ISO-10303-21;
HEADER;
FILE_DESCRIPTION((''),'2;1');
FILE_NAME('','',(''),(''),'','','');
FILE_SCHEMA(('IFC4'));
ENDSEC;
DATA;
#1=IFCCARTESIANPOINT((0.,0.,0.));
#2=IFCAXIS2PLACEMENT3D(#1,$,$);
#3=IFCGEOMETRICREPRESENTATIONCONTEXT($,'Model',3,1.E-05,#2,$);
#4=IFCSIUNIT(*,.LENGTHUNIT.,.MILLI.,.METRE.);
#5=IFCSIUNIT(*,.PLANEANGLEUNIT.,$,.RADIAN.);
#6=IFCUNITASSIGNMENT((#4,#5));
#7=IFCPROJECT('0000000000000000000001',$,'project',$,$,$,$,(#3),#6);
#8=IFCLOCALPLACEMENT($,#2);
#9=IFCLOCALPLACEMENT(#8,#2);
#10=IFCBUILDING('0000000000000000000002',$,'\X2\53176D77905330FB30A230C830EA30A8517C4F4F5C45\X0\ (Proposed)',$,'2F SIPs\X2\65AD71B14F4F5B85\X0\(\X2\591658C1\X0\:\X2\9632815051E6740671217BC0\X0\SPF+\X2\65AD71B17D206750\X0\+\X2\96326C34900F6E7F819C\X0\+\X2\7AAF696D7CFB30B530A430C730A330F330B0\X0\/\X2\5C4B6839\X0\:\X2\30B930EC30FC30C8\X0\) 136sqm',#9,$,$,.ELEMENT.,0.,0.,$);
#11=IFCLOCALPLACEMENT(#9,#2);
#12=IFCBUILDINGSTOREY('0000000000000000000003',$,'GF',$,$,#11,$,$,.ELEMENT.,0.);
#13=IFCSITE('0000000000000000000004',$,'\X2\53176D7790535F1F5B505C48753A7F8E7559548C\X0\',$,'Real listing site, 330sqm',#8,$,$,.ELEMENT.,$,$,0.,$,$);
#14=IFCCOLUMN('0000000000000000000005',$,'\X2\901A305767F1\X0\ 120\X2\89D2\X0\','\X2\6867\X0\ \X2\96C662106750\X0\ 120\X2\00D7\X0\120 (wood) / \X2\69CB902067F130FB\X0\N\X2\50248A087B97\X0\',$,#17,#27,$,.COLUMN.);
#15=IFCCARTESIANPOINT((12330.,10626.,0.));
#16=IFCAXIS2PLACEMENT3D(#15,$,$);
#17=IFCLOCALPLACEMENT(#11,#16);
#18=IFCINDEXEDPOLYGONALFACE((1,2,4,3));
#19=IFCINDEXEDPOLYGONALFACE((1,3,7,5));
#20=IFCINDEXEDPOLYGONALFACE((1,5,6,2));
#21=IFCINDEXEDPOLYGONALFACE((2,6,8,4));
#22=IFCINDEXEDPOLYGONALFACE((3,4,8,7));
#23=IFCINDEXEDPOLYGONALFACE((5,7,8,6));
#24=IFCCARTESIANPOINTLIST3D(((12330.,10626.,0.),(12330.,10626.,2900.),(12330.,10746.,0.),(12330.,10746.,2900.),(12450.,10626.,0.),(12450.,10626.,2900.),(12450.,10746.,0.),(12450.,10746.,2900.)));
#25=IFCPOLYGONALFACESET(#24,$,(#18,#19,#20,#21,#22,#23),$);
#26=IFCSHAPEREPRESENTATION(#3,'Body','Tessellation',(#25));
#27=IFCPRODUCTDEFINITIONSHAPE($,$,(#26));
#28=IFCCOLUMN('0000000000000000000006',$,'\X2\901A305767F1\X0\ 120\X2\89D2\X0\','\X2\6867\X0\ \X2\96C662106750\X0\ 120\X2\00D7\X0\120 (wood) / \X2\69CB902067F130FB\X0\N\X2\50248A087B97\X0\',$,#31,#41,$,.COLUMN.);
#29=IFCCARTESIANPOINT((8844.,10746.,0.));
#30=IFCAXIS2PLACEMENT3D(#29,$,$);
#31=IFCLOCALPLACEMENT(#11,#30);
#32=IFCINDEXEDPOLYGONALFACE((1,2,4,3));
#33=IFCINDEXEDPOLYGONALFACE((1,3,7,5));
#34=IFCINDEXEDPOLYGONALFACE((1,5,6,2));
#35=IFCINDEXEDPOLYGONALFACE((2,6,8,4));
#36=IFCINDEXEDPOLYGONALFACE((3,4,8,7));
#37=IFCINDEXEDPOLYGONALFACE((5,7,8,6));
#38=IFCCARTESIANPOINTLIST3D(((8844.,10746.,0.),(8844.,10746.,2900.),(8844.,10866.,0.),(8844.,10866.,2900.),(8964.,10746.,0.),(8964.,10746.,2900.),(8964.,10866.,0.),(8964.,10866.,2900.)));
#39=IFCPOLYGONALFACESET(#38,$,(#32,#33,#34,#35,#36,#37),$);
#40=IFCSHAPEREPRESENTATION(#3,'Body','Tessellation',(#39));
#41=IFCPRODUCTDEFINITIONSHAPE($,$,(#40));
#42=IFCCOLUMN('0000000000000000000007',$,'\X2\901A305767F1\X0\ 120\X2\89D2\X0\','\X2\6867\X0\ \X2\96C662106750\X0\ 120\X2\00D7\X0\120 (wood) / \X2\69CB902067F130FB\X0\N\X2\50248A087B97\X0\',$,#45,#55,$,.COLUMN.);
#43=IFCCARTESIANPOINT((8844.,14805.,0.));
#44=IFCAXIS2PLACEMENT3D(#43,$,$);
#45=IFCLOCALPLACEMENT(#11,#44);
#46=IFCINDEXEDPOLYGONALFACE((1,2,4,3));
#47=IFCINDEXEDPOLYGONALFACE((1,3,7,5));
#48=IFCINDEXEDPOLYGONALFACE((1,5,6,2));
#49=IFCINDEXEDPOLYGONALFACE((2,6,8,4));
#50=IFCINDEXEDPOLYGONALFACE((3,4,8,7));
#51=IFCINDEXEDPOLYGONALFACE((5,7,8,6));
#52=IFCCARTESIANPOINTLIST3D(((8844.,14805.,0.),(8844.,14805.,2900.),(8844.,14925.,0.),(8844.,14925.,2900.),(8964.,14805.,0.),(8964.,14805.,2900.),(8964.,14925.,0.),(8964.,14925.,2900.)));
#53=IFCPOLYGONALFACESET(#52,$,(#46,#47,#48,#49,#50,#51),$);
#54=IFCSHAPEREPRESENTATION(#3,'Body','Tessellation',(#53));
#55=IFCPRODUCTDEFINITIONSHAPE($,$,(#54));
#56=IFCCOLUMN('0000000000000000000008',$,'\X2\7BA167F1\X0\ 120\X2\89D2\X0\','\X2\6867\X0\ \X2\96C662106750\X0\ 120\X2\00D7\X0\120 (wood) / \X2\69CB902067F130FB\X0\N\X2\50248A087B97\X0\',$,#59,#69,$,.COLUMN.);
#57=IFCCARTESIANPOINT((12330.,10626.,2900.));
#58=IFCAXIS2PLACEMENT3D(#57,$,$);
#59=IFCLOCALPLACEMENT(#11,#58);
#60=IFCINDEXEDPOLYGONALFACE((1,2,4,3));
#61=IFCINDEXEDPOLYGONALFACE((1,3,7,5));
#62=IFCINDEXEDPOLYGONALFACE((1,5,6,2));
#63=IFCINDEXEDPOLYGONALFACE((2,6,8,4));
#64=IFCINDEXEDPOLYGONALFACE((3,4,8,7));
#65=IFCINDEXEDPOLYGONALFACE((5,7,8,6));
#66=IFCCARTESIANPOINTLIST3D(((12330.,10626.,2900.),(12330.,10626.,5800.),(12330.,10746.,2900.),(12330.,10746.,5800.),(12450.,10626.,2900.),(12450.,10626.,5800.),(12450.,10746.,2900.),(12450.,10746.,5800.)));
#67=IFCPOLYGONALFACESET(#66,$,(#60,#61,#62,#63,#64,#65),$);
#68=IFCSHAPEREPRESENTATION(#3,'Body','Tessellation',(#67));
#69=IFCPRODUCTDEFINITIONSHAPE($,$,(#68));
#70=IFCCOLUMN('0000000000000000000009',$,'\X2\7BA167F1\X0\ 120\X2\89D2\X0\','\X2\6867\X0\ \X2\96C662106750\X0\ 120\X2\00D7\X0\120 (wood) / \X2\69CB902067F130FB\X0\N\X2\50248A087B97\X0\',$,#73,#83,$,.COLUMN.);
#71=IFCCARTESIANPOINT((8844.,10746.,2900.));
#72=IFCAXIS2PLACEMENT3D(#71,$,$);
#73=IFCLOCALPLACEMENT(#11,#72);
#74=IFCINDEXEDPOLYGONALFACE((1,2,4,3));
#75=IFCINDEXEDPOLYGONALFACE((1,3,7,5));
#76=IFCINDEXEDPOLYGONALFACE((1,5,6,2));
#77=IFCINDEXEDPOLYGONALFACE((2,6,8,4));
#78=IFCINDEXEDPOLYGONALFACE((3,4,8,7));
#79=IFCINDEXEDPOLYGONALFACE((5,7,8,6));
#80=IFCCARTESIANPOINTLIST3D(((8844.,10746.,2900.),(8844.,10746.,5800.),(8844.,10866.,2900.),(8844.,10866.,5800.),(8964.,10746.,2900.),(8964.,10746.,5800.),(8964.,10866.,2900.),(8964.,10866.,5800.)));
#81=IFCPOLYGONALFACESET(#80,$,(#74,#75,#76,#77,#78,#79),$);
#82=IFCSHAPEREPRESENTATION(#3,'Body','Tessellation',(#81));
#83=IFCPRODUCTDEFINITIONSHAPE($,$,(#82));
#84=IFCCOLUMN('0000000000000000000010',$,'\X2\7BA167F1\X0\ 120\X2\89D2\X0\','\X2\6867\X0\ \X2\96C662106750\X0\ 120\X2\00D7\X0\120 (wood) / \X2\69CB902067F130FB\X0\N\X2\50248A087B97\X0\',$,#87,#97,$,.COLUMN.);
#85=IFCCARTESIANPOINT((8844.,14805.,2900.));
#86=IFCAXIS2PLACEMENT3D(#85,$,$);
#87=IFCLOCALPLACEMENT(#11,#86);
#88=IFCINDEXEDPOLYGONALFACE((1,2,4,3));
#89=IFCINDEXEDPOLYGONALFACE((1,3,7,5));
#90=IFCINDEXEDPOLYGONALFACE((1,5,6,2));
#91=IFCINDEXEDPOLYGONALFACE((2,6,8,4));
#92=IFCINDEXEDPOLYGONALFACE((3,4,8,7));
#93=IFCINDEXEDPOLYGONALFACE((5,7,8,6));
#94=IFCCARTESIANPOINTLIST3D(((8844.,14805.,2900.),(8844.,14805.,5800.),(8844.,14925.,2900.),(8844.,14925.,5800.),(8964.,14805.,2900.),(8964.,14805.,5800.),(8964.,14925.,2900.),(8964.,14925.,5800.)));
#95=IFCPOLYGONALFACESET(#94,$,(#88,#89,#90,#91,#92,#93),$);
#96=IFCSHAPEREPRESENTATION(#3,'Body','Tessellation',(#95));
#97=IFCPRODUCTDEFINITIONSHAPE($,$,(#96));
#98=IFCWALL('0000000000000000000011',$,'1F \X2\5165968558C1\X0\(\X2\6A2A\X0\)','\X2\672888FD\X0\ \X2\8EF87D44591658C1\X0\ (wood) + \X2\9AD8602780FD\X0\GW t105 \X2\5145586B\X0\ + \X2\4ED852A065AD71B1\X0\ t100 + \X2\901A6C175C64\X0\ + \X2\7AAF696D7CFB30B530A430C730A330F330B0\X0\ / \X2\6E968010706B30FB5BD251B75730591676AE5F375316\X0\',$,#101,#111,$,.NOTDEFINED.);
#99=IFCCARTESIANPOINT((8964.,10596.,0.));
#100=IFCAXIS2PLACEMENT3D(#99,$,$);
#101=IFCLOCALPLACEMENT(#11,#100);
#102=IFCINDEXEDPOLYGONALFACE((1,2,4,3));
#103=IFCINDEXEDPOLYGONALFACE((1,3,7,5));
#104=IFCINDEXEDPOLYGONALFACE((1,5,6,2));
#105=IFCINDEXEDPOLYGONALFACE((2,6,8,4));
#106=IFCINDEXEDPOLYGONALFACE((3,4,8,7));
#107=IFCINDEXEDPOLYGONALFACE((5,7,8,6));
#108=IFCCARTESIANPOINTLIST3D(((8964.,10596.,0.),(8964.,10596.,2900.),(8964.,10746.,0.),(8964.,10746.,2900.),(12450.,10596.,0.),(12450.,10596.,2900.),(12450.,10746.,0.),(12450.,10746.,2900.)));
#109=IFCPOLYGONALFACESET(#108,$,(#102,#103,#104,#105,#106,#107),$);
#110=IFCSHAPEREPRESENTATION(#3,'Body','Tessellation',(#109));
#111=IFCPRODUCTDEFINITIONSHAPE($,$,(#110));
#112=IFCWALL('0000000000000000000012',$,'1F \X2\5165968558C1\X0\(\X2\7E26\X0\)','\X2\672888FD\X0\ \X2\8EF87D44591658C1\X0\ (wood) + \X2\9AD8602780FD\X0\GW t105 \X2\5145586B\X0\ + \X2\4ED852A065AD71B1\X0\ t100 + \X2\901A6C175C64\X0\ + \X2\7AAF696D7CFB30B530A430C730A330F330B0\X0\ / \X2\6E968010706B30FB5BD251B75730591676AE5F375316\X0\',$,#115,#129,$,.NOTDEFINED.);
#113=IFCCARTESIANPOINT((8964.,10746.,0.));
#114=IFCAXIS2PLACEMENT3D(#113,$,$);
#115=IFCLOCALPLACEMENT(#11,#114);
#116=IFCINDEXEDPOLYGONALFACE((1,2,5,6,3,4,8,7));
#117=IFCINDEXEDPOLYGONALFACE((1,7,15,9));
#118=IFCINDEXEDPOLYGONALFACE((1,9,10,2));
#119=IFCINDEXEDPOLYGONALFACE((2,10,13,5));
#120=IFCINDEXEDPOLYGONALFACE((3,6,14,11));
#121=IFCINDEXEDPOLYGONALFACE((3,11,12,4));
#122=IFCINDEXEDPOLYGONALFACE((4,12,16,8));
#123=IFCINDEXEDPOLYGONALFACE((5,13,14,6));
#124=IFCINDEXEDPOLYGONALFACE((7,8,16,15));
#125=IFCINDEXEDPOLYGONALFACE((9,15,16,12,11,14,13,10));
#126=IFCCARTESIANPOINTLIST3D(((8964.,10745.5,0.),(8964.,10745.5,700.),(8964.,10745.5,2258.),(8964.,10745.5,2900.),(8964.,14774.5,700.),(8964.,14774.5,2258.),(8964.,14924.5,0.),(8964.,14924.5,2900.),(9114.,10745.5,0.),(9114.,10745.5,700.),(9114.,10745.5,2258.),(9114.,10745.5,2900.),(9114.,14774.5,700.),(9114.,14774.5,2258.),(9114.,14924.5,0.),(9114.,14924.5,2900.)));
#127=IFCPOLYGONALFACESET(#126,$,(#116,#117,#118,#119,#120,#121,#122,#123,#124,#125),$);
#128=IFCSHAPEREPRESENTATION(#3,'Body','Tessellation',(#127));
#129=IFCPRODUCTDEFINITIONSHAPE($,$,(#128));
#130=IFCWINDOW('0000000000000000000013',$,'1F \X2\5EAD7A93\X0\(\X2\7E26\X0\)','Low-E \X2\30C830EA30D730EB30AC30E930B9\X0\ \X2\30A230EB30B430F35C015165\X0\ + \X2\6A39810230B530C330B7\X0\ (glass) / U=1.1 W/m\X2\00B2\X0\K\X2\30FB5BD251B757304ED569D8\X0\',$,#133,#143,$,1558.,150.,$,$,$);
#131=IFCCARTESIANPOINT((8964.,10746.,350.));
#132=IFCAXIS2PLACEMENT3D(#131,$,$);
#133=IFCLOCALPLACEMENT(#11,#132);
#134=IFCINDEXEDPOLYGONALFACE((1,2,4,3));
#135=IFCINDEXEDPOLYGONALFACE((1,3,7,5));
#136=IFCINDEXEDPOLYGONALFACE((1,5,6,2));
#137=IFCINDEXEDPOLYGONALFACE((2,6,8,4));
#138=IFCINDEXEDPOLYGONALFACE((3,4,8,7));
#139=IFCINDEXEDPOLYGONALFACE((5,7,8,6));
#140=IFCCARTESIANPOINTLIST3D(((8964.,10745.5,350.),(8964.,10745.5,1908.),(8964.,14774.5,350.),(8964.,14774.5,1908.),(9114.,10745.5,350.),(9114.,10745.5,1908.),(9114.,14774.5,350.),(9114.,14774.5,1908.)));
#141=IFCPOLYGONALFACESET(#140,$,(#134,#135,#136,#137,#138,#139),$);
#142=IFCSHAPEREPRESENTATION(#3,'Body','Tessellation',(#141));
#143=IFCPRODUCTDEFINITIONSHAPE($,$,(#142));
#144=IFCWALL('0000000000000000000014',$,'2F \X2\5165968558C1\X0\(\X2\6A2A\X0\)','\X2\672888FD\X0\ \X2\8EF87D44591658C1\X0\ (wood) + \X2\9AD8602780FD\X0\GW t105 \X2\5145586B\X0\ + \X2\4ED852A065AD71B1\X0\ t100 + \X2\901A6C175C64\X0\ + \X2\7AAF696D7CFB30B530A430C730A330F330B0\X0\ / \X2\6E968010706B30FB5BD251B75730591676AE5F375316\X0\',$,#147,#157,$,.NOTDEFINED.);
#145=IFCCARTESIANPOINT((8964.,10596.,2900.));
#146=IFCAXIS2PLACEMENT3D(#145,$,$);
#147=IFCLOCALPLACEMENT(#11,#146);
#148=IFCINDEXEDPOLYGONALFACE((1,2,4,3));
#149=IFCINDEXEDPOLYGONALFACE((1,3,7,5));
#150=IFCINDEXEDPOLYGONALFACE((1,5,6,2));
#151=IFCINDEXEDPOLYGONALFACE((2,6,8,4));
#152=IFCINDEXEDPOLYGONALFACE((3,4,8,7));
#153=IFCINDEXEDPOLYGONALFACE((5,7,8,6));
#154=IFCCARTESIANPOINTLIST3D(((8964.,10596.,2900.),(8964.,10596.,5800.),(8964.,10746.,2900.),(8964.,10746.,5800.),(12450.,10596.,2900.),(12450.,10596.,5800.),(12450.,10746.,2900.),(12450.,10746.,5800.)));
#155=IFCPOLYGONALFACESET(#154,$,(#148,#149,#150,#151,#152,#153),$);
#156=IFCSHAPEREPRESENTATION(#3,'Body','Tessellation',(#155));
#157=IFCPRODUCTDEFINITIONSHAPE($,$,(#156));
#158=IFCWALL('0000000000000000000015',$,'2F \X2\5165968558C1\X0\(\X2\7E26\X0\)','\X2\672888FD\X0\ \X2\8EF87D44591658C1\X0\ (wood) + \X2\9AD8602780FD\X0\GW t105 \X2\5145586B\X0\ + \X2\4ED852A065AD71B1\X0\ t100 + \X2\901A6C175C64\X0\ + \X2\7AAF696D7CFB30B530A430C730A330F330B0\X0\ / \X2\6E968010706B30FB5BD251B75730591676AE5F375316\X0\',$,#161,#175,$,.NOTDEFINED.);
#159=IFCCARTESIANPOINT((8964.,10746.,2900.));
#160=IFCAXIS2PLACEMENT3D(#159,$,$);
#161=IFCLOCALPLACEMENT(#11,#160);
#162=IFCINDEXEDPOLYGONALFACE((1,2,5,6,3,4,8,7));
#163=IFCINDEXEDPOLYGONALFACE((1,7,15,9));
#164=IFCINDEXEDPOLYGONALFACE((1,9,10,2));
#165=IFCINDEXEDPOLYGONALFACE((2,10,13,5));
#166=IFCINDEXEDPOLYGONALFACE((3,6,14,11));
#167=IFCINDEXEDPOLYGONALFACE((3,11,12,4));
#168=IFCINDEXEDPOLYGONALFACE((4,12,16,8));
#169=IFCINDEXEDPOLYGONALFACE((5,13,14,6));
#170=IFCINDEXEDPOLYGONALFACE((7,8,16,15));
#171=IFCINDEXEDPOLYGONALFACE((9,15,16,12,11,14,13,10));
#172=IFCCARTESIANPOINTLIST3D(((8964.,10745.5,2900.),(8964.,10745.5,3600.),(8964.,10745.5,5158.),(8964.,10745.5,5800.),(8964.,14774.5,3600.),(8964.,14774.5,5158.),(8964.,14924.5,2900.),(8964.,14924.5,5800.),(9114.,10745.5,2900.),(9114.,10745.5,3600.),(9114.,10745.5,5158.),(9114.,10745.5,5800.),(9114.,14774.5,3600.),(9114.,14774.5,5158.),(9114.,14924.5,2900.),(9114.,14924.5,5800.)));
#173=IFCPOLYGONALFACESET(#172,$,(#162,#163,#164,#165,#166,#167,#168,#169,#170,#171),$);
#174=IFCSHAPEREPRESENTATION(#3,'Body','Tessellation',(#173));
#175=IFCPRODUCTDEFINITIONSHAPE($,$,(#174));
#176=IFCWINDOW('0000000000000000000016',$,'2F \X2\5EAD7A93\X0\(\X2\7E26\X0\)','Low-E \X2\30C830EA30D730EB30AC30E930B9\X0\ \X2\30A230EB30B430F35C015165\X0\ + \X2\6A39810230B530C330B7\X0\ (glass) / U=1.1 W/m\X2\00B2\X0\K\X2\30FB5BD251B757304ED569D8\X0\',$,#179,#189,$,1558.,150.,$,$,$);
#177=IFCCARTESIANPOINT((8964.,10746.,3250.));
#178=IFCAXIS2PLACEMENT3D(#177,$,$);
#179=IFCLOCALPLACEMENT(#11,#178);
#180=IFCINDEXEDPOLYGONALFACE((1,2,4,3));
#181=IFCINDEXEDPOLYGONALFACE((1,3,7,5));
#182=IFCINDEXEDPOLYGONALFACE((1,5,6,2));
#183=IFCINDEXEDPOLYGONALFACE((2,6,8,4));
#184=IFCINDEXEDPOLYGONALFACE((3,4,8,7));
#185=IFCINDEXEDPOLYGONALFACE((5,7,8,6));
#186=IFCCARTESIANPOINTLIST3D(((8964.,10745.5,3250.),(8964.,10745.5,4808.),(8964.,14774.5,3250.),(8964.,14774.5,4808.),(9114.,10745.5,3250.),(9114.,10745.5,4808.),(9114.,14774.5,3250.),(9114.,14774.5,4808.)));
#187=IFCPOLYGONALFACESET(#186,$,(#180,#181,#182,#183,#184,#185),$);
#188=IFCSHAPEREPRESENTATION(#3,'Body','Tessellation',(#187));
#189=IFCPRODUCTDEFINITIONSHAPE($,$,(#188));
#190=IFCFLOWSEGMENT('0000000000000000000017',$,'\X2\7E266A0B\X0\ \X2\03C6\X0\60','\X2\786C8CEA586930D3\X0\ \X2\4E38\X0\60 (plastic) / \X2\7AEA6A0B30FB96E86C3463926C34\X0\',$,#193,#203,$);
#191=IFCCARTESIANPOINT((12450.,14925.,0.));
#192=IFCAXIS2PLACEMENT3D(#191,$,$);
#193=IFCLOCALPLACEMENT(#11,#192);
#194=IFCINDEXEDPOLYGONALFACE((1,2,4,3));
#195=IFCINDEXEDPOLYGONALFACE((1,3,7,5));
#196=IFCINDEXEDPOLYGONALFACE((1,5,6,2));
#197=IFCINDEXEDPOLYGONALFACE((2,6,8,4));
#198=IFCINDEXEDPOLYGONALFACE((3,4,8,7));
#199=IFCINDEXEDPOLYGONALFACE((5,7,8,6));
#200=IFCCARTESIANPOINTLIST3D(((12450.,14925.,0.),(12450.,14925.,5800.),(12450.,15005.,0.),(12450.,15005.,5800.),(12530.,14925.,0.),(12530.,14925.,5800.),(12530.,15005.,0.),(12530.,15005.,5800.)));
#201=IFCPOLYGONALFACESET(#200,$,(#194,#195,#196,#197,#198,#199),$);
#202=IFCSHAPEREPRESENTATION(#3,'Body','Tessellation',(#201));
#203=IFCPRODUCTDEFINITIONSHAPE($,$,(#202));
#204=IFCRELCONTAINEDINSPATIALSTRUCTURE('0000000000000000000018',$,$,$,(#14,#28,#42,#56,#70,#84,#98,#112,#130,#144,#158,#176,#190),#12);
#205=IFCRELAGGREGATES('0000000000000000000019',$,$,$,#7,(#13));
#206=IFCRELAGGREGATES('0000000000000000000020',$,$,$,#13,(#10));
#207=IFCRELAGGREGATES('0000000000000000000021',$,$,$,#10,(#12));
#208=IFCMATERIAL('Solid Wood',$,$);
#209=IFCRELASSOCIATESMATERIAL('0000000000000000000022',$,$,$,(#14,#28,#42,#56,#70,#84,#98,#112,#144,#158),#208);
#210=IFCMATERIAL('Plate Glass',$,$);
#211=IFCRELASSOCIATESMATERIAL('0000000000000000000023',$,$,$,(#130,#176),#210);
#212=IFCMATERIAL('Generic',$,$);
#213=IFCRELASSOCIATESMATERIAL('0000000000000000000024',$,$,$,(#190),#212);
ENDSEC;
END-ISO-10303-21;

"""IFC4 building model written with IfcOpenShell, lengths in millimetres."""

from ifc_helpers import new_model, si_unit, frame, frame_2d, origin, place, context, project, spatial, rectangle, extrude, material, element, fill, save


model = new_model("IFC4")

# Units and contexts
model_context = context("Model", 3, precision=1e-05, world=origin())
ifc_project = project(units=[si_unit("LENGTHUNIT", "METRE", prefix="MILLI"), si_unit("PLANEANGLEUNIT", "RADIAN")], contexts=[model_context])

# Site, building, storey
site_placement = place(None, origin())
site = spatial("IfcSite", under=ifc_project, at=site_placement, Name="北海道弟子屈町美留和", ObjectType="Real listing site, 330sqm", CompositionType="ELEMENT", RefElevation=0.0)
building_placement = place(site_placement, origin())
building = spatial("IfcBuilding", under=site, at=building_placement, Name="北海道・アトリエ兼住居 (Proposed)", ObjectType="2F SIPs断熱住宅(外壁:防腐処理無節SPF+断熱素材+防水透湿膜+窯業系サイディング/屋根:スレート) 136sqm", CompositionType="ELEMENT", ElevationOfRefHeight=0.0, ElevationOfTerrain=0.0)
storey_placement = place(building_placement, origin())
storey = spatial("IfcBuildingStorey", under=building, at=storey_placement, Name="GF", CompositionType="ELEMENT", Elevation=0.0)

# Columns
ifc_material_1 = material(Name="Solid Wood")
column_1_placement = place(storey_placement, frame((12330.0, 10626.0, 0.0)))
element("IfcColumn", 1, at=column_1_placement, inside=storey, material=ifc_material_1, Name="通し柱 120角", Description="桧 集成材 120×120 (wood) / 構造柱・N値計算", PredefinedType="COLUMN", context=model_context, shape_type="SweptSolid", body=[
    extrude(rectangle(XDim=120.0, YDim=120.0, at=frame_2d((60.0, 60.0))), frame((12330.0, 10626.0, 0.0)), (0.0, 0.0, 1.0), 2900.0),
])
column_2_placement = place(storey_placement, frame((8844.0, 10746.0, 0.0)))
element("IfcColumn", 2, at=column_2_placement, inside=storey, material=ifc_material_1, Name="通し柱 120角", Description="桧 集成材 120×120 (wood) / 構造柱・N値計算", PredefinedType="COLUMN", context=model_context, shape_type="SweptSolid", body=[
    extrude(rectangle(XDim=120.0, YDim=120.0, at=frame_2d((60.0, 60.0))), frame((8844.0, 10746.0, 0.0)), (0.0, 0.0, 1.0), 2900.0),
])
column_3_placement = place(storey_placement, frame((8844.0, 14805.0, 0.0)))
element("IfcColumn", 3, at=column_3_placement, inside=storey, material=ifc_material_1, Name="通し柱 120角", Description="桧 集成材 120×120 (wood) / 構造柱・N値計算", PredefinedType="COLUMN", context=model_context, shape_type="SweptSolid", body=[
    extrude(rectangle(XDim=120.0, YDim=120.0, at=frame_2d((60.0, 60.0))), frame((8844.0, 14805.0, 0.0)), (0.0, 0.0, 1.0), 2900.0),
])
column_4_placement = place(storey_placement, frame((12330.0, 10626.0, 2900.0)))
element("IfcColumn", 4, at=column_4_placement, inside=storey, material=ifc_material_1, Name="管柱 120角", Description="桧 集成材 120×120 (wood) / 構造柱・N値計算", PredefinedType="COLUMN", context=model_context, shape_type="SweptSolid", body=[
    extrude(rectangle(XDim=120.0, YDim=120.0, at=frame_2d((60.0, 60.0))), frame((12330.0, 10626.0, 2900.0)), (0.0, 0.0, 1.0), 2900.0),
])
column_5_placement = place(storey_placement, frame((8844.0, 10746.0, 2900.0)))
element("IfcColumn", 5, at=column_5_placement, inside=storey, material=ifc_material_1, Name="管柱 120角", Description="桧 集成材 120×120 (wood) / 構造柱・N値計算", PredefinedType="COLUMN", context=model_context, shape_type="SweptSolid", body=[
    extrude(rectangle(XDim=120.0, YDim=120.0, at=frame_2d((60.0, 60.0))), frame((8844.0, 10746.0, 2900.0)), (0.0, 0.0, 1.0), 2900.0),
])
column_6_placement = place(storey_placement, frame((8844.0, 14805.0, 2900.0)))
element("IfcColumn", 6, at=column_6_placement, inside=storey, material=ifc_material_1, Name="管柱 120角", Description="桧 集成材 120×120 (wood) / 構造柱・N値計算", PredefinedType="COLUMN", context=model_context, shape_type="SweptSolid", body=[
    extrude(rectangle(XDim=120.0, YDim=120.0, at=frame_2d((60.0, 60.0))), frame((8844.0, 14805.0, 2900.0)), (0.0, 0.0, 1.0), 2900.0),
])

# Wall
wall_1_placement = place(storey_placement, frame((8964.0, 10596.0, 0.0)))
element("IfcWall", 7, at=wall_1_placement, inside=storey, material=ifc_material_1, Name="1F 入隅壁(横)", Description="木製 軸組外壁 (wood) + 高性能GW t105 充填 + 付加断熱 t100 + 通気層 + 窯業系サイディング / 準耐火・寒冷地外皮強化", PredefinedType="NOTDEFINED", context=model_context, shape_type="SweptSolid", body=[
    extrude(rectangle(XDim=3486.0, YDim=150.0, at=frame_2d((1743.0, 75.0))), frame((8964.0, 10596.0, 0.0)), (0.0, 0.0, 1.0), 2900.0),
])

# Wall, opening, window
wall_2_placement = place(storey_placement, frame((8964.0, 10746.0, 0.0)))
wall_2 = element("IfcWall", 8, at=wall_2_placement, inside=storey, material=ifc_material_1, Name="1F 入隅壁(縦)", Description="木製 軸組外壁 (wood) + 高性能GW t105 充填 + 付加断熱 t100 + 通気層 + 窯業系サイディング / 準耐火・寒冷地外皮強化", PredefinedType="NOTDEFINED", context=model_context, shape_type="SweptSolid", body=[
    extrude(rectangle(XDim=150.0, YDim=4179.0, at=frame_2d((75.0, 2089.0))), frame((8964.0, 10746.0, 0.0)), (0.0, 0.0, 1.0), 2900.0),
])
opening_1_placement = place(storey_placement, frame((8964.0, 10746.0, 350.0)))
opening_1 = element("IfcOpeningElement", 9, at=opening_1_placement, cuts=wall_2, PredefinedType="NOTDEFINED", context=model_context, shape_type="SweptSolid", body=[
    extrude(rectangle(XDim=150.0, YDim=4029.0, at=frame_2d((75.0, 2014.0))), frame((8964.0, 10746.0, 350.0)), (0.0, 0.0, 1.0), 1558.0),
])
ifc_material_2 = material(Name="Plate Glass")
window_1_placement = place(storey_placement, frame((8964.0, 10746.0, 350.0)))
window_1 = element("IfcWindow", 10, at=window_1_placement, inside=storey, material=ifc_material_2, Name="1F 庭窓(縦)", Description="Low-E トリプルガラス アルゴン封入 + 樹脂サッシ (glass) / U=1.1 W/m²K・寒冷地仕様", OverallHeight=1558.0, OverallWidth=150.0, context=model_context, shape_type="SweptSolid", body=[
    extrude(rectangle(XDim=150.0, YDim=4029.0, at=frame_2d((75.0, 2014.0))), frame((8964.0, 10746.0, 350.0)), (0.0, 0.0, 1.0), 1558.0),
])
fill(opening_1, window_1)

# Wall
wall_3_placement = place(storey_placement, frame((8964.0, 10596.0, 2900.0)))
element("IfcWall", 11, at=wall_3_placement, inside=storey, material=ifc_material_1, Name="2F 入隅壁(横)", Description="木製 軸組外壁 (wood) + 高性能GW t105 充填 + 付加断熱 t100 + 通気層 + 窯業系サイディング / 準耐火・寒冷地外皮強化", PredefinedType="NOTDEFINED", context=model_context, shape_type="SweptSolid", body=[
    extrude(rectangle(XDim=3486.0, YDim=150.0, at=frame_2d((1743.0, 75.0))), frame((8964.0, 10596.0, 2900.0)), (0.0, 0.0, 1.0), 2900.0),
])

# Wall, opening, window
wall_4_placement = place(storey_placement, frame((8964.0, 10746.0, 2900.0)))
wall_4 = element("IfcWall", 12, at=wall_4_placement, inside=storey, material=ifc_material_1, Name="2F 入隅壁(縦)", Description="木製 軸組外壁 (wood) + 高性能GW t105 充填 + 付加断熱 t100 + 通気層 + 窯業系サイディング / 準耐火・寒冷地外皮強化", PredefinedType="NOTDEFINED", context=model_context, shape_type="SweptSolid", body=[
    extrude(rectangle(XDim=150.0, YDim=4179.0, at=frame_2d((75.0, 2089.0))), frame((8964.0, 10746.0, 2900.0)), (0.0, 0.0, 1.0), 2900.0),
])
opening_2_placement = place(storey_placement, frame((8964.0, 10746.0, 3250.0)))
opening_2 = element("IfcOpeningElement", 13, at=opening_2_placement, cuts=wall_4, PredefinedType="NOTDEFINED", context=model_context, shape_type="SweptSolid", body=[
    extrude(rectangle(XDim=150.0, YDim=4029.0, at=frame_2d((75.0, 2014.0))), frame((8964.0, 10746.0, 3250.0)), (0.0, 0.0, 1.0), 1558.0),
])
window_2_placement = place(storey_placement, frame((8964.0, 10746.0, 3250.0)))
window_2 = element("IfcWindow", 14, at=window_2_placement, inside=storey, material=ifc_material_2, Name="2F 庭窓(縦)", Description="Low-E トリプルガラス アルゴン封入 + 樹脂サッシ (glass) / U=1.1 W/m²K・寒冷地仕様", OverallHeight=1558.0, OverallWidth=150.0, context=model_context, shape_type="SweptSolid", body=[
    extrude(rectangle(XDim=150.0, YDim=4029.0, at=frame_2d((75.0, 2014.0))), frame((8964.0, 10746.0, 3250.0)), (0.0, 0.0, 1.0), 1558.0),
])
fill(opening_2, window_2)

# Flow segment
ifc_material_3 = material(Name="Generic")
flow_segment_placement = place(storey_placement, frame((12450.0, 14925.0, 0.0)))
element("IfcFlowSegment", 15, at=flow_segment_placement, inside=storey, material=ifc_material_3, Name="縦樋 φ60", Description="硬質塩ビ 丸60 (plastic) / 竪樋・雨水排水", context=model_context, shape_type="SweptSolid", body=[
    extrude(rectangle(XDim=80.0, YDim=80.0, at=frame_2d((40.0, 40.0))), frame((12450.0, 14925.0, 0.0)), (0.0, 0.0, 1.0), 5800.0),
])

save(model, "model.ifc")
